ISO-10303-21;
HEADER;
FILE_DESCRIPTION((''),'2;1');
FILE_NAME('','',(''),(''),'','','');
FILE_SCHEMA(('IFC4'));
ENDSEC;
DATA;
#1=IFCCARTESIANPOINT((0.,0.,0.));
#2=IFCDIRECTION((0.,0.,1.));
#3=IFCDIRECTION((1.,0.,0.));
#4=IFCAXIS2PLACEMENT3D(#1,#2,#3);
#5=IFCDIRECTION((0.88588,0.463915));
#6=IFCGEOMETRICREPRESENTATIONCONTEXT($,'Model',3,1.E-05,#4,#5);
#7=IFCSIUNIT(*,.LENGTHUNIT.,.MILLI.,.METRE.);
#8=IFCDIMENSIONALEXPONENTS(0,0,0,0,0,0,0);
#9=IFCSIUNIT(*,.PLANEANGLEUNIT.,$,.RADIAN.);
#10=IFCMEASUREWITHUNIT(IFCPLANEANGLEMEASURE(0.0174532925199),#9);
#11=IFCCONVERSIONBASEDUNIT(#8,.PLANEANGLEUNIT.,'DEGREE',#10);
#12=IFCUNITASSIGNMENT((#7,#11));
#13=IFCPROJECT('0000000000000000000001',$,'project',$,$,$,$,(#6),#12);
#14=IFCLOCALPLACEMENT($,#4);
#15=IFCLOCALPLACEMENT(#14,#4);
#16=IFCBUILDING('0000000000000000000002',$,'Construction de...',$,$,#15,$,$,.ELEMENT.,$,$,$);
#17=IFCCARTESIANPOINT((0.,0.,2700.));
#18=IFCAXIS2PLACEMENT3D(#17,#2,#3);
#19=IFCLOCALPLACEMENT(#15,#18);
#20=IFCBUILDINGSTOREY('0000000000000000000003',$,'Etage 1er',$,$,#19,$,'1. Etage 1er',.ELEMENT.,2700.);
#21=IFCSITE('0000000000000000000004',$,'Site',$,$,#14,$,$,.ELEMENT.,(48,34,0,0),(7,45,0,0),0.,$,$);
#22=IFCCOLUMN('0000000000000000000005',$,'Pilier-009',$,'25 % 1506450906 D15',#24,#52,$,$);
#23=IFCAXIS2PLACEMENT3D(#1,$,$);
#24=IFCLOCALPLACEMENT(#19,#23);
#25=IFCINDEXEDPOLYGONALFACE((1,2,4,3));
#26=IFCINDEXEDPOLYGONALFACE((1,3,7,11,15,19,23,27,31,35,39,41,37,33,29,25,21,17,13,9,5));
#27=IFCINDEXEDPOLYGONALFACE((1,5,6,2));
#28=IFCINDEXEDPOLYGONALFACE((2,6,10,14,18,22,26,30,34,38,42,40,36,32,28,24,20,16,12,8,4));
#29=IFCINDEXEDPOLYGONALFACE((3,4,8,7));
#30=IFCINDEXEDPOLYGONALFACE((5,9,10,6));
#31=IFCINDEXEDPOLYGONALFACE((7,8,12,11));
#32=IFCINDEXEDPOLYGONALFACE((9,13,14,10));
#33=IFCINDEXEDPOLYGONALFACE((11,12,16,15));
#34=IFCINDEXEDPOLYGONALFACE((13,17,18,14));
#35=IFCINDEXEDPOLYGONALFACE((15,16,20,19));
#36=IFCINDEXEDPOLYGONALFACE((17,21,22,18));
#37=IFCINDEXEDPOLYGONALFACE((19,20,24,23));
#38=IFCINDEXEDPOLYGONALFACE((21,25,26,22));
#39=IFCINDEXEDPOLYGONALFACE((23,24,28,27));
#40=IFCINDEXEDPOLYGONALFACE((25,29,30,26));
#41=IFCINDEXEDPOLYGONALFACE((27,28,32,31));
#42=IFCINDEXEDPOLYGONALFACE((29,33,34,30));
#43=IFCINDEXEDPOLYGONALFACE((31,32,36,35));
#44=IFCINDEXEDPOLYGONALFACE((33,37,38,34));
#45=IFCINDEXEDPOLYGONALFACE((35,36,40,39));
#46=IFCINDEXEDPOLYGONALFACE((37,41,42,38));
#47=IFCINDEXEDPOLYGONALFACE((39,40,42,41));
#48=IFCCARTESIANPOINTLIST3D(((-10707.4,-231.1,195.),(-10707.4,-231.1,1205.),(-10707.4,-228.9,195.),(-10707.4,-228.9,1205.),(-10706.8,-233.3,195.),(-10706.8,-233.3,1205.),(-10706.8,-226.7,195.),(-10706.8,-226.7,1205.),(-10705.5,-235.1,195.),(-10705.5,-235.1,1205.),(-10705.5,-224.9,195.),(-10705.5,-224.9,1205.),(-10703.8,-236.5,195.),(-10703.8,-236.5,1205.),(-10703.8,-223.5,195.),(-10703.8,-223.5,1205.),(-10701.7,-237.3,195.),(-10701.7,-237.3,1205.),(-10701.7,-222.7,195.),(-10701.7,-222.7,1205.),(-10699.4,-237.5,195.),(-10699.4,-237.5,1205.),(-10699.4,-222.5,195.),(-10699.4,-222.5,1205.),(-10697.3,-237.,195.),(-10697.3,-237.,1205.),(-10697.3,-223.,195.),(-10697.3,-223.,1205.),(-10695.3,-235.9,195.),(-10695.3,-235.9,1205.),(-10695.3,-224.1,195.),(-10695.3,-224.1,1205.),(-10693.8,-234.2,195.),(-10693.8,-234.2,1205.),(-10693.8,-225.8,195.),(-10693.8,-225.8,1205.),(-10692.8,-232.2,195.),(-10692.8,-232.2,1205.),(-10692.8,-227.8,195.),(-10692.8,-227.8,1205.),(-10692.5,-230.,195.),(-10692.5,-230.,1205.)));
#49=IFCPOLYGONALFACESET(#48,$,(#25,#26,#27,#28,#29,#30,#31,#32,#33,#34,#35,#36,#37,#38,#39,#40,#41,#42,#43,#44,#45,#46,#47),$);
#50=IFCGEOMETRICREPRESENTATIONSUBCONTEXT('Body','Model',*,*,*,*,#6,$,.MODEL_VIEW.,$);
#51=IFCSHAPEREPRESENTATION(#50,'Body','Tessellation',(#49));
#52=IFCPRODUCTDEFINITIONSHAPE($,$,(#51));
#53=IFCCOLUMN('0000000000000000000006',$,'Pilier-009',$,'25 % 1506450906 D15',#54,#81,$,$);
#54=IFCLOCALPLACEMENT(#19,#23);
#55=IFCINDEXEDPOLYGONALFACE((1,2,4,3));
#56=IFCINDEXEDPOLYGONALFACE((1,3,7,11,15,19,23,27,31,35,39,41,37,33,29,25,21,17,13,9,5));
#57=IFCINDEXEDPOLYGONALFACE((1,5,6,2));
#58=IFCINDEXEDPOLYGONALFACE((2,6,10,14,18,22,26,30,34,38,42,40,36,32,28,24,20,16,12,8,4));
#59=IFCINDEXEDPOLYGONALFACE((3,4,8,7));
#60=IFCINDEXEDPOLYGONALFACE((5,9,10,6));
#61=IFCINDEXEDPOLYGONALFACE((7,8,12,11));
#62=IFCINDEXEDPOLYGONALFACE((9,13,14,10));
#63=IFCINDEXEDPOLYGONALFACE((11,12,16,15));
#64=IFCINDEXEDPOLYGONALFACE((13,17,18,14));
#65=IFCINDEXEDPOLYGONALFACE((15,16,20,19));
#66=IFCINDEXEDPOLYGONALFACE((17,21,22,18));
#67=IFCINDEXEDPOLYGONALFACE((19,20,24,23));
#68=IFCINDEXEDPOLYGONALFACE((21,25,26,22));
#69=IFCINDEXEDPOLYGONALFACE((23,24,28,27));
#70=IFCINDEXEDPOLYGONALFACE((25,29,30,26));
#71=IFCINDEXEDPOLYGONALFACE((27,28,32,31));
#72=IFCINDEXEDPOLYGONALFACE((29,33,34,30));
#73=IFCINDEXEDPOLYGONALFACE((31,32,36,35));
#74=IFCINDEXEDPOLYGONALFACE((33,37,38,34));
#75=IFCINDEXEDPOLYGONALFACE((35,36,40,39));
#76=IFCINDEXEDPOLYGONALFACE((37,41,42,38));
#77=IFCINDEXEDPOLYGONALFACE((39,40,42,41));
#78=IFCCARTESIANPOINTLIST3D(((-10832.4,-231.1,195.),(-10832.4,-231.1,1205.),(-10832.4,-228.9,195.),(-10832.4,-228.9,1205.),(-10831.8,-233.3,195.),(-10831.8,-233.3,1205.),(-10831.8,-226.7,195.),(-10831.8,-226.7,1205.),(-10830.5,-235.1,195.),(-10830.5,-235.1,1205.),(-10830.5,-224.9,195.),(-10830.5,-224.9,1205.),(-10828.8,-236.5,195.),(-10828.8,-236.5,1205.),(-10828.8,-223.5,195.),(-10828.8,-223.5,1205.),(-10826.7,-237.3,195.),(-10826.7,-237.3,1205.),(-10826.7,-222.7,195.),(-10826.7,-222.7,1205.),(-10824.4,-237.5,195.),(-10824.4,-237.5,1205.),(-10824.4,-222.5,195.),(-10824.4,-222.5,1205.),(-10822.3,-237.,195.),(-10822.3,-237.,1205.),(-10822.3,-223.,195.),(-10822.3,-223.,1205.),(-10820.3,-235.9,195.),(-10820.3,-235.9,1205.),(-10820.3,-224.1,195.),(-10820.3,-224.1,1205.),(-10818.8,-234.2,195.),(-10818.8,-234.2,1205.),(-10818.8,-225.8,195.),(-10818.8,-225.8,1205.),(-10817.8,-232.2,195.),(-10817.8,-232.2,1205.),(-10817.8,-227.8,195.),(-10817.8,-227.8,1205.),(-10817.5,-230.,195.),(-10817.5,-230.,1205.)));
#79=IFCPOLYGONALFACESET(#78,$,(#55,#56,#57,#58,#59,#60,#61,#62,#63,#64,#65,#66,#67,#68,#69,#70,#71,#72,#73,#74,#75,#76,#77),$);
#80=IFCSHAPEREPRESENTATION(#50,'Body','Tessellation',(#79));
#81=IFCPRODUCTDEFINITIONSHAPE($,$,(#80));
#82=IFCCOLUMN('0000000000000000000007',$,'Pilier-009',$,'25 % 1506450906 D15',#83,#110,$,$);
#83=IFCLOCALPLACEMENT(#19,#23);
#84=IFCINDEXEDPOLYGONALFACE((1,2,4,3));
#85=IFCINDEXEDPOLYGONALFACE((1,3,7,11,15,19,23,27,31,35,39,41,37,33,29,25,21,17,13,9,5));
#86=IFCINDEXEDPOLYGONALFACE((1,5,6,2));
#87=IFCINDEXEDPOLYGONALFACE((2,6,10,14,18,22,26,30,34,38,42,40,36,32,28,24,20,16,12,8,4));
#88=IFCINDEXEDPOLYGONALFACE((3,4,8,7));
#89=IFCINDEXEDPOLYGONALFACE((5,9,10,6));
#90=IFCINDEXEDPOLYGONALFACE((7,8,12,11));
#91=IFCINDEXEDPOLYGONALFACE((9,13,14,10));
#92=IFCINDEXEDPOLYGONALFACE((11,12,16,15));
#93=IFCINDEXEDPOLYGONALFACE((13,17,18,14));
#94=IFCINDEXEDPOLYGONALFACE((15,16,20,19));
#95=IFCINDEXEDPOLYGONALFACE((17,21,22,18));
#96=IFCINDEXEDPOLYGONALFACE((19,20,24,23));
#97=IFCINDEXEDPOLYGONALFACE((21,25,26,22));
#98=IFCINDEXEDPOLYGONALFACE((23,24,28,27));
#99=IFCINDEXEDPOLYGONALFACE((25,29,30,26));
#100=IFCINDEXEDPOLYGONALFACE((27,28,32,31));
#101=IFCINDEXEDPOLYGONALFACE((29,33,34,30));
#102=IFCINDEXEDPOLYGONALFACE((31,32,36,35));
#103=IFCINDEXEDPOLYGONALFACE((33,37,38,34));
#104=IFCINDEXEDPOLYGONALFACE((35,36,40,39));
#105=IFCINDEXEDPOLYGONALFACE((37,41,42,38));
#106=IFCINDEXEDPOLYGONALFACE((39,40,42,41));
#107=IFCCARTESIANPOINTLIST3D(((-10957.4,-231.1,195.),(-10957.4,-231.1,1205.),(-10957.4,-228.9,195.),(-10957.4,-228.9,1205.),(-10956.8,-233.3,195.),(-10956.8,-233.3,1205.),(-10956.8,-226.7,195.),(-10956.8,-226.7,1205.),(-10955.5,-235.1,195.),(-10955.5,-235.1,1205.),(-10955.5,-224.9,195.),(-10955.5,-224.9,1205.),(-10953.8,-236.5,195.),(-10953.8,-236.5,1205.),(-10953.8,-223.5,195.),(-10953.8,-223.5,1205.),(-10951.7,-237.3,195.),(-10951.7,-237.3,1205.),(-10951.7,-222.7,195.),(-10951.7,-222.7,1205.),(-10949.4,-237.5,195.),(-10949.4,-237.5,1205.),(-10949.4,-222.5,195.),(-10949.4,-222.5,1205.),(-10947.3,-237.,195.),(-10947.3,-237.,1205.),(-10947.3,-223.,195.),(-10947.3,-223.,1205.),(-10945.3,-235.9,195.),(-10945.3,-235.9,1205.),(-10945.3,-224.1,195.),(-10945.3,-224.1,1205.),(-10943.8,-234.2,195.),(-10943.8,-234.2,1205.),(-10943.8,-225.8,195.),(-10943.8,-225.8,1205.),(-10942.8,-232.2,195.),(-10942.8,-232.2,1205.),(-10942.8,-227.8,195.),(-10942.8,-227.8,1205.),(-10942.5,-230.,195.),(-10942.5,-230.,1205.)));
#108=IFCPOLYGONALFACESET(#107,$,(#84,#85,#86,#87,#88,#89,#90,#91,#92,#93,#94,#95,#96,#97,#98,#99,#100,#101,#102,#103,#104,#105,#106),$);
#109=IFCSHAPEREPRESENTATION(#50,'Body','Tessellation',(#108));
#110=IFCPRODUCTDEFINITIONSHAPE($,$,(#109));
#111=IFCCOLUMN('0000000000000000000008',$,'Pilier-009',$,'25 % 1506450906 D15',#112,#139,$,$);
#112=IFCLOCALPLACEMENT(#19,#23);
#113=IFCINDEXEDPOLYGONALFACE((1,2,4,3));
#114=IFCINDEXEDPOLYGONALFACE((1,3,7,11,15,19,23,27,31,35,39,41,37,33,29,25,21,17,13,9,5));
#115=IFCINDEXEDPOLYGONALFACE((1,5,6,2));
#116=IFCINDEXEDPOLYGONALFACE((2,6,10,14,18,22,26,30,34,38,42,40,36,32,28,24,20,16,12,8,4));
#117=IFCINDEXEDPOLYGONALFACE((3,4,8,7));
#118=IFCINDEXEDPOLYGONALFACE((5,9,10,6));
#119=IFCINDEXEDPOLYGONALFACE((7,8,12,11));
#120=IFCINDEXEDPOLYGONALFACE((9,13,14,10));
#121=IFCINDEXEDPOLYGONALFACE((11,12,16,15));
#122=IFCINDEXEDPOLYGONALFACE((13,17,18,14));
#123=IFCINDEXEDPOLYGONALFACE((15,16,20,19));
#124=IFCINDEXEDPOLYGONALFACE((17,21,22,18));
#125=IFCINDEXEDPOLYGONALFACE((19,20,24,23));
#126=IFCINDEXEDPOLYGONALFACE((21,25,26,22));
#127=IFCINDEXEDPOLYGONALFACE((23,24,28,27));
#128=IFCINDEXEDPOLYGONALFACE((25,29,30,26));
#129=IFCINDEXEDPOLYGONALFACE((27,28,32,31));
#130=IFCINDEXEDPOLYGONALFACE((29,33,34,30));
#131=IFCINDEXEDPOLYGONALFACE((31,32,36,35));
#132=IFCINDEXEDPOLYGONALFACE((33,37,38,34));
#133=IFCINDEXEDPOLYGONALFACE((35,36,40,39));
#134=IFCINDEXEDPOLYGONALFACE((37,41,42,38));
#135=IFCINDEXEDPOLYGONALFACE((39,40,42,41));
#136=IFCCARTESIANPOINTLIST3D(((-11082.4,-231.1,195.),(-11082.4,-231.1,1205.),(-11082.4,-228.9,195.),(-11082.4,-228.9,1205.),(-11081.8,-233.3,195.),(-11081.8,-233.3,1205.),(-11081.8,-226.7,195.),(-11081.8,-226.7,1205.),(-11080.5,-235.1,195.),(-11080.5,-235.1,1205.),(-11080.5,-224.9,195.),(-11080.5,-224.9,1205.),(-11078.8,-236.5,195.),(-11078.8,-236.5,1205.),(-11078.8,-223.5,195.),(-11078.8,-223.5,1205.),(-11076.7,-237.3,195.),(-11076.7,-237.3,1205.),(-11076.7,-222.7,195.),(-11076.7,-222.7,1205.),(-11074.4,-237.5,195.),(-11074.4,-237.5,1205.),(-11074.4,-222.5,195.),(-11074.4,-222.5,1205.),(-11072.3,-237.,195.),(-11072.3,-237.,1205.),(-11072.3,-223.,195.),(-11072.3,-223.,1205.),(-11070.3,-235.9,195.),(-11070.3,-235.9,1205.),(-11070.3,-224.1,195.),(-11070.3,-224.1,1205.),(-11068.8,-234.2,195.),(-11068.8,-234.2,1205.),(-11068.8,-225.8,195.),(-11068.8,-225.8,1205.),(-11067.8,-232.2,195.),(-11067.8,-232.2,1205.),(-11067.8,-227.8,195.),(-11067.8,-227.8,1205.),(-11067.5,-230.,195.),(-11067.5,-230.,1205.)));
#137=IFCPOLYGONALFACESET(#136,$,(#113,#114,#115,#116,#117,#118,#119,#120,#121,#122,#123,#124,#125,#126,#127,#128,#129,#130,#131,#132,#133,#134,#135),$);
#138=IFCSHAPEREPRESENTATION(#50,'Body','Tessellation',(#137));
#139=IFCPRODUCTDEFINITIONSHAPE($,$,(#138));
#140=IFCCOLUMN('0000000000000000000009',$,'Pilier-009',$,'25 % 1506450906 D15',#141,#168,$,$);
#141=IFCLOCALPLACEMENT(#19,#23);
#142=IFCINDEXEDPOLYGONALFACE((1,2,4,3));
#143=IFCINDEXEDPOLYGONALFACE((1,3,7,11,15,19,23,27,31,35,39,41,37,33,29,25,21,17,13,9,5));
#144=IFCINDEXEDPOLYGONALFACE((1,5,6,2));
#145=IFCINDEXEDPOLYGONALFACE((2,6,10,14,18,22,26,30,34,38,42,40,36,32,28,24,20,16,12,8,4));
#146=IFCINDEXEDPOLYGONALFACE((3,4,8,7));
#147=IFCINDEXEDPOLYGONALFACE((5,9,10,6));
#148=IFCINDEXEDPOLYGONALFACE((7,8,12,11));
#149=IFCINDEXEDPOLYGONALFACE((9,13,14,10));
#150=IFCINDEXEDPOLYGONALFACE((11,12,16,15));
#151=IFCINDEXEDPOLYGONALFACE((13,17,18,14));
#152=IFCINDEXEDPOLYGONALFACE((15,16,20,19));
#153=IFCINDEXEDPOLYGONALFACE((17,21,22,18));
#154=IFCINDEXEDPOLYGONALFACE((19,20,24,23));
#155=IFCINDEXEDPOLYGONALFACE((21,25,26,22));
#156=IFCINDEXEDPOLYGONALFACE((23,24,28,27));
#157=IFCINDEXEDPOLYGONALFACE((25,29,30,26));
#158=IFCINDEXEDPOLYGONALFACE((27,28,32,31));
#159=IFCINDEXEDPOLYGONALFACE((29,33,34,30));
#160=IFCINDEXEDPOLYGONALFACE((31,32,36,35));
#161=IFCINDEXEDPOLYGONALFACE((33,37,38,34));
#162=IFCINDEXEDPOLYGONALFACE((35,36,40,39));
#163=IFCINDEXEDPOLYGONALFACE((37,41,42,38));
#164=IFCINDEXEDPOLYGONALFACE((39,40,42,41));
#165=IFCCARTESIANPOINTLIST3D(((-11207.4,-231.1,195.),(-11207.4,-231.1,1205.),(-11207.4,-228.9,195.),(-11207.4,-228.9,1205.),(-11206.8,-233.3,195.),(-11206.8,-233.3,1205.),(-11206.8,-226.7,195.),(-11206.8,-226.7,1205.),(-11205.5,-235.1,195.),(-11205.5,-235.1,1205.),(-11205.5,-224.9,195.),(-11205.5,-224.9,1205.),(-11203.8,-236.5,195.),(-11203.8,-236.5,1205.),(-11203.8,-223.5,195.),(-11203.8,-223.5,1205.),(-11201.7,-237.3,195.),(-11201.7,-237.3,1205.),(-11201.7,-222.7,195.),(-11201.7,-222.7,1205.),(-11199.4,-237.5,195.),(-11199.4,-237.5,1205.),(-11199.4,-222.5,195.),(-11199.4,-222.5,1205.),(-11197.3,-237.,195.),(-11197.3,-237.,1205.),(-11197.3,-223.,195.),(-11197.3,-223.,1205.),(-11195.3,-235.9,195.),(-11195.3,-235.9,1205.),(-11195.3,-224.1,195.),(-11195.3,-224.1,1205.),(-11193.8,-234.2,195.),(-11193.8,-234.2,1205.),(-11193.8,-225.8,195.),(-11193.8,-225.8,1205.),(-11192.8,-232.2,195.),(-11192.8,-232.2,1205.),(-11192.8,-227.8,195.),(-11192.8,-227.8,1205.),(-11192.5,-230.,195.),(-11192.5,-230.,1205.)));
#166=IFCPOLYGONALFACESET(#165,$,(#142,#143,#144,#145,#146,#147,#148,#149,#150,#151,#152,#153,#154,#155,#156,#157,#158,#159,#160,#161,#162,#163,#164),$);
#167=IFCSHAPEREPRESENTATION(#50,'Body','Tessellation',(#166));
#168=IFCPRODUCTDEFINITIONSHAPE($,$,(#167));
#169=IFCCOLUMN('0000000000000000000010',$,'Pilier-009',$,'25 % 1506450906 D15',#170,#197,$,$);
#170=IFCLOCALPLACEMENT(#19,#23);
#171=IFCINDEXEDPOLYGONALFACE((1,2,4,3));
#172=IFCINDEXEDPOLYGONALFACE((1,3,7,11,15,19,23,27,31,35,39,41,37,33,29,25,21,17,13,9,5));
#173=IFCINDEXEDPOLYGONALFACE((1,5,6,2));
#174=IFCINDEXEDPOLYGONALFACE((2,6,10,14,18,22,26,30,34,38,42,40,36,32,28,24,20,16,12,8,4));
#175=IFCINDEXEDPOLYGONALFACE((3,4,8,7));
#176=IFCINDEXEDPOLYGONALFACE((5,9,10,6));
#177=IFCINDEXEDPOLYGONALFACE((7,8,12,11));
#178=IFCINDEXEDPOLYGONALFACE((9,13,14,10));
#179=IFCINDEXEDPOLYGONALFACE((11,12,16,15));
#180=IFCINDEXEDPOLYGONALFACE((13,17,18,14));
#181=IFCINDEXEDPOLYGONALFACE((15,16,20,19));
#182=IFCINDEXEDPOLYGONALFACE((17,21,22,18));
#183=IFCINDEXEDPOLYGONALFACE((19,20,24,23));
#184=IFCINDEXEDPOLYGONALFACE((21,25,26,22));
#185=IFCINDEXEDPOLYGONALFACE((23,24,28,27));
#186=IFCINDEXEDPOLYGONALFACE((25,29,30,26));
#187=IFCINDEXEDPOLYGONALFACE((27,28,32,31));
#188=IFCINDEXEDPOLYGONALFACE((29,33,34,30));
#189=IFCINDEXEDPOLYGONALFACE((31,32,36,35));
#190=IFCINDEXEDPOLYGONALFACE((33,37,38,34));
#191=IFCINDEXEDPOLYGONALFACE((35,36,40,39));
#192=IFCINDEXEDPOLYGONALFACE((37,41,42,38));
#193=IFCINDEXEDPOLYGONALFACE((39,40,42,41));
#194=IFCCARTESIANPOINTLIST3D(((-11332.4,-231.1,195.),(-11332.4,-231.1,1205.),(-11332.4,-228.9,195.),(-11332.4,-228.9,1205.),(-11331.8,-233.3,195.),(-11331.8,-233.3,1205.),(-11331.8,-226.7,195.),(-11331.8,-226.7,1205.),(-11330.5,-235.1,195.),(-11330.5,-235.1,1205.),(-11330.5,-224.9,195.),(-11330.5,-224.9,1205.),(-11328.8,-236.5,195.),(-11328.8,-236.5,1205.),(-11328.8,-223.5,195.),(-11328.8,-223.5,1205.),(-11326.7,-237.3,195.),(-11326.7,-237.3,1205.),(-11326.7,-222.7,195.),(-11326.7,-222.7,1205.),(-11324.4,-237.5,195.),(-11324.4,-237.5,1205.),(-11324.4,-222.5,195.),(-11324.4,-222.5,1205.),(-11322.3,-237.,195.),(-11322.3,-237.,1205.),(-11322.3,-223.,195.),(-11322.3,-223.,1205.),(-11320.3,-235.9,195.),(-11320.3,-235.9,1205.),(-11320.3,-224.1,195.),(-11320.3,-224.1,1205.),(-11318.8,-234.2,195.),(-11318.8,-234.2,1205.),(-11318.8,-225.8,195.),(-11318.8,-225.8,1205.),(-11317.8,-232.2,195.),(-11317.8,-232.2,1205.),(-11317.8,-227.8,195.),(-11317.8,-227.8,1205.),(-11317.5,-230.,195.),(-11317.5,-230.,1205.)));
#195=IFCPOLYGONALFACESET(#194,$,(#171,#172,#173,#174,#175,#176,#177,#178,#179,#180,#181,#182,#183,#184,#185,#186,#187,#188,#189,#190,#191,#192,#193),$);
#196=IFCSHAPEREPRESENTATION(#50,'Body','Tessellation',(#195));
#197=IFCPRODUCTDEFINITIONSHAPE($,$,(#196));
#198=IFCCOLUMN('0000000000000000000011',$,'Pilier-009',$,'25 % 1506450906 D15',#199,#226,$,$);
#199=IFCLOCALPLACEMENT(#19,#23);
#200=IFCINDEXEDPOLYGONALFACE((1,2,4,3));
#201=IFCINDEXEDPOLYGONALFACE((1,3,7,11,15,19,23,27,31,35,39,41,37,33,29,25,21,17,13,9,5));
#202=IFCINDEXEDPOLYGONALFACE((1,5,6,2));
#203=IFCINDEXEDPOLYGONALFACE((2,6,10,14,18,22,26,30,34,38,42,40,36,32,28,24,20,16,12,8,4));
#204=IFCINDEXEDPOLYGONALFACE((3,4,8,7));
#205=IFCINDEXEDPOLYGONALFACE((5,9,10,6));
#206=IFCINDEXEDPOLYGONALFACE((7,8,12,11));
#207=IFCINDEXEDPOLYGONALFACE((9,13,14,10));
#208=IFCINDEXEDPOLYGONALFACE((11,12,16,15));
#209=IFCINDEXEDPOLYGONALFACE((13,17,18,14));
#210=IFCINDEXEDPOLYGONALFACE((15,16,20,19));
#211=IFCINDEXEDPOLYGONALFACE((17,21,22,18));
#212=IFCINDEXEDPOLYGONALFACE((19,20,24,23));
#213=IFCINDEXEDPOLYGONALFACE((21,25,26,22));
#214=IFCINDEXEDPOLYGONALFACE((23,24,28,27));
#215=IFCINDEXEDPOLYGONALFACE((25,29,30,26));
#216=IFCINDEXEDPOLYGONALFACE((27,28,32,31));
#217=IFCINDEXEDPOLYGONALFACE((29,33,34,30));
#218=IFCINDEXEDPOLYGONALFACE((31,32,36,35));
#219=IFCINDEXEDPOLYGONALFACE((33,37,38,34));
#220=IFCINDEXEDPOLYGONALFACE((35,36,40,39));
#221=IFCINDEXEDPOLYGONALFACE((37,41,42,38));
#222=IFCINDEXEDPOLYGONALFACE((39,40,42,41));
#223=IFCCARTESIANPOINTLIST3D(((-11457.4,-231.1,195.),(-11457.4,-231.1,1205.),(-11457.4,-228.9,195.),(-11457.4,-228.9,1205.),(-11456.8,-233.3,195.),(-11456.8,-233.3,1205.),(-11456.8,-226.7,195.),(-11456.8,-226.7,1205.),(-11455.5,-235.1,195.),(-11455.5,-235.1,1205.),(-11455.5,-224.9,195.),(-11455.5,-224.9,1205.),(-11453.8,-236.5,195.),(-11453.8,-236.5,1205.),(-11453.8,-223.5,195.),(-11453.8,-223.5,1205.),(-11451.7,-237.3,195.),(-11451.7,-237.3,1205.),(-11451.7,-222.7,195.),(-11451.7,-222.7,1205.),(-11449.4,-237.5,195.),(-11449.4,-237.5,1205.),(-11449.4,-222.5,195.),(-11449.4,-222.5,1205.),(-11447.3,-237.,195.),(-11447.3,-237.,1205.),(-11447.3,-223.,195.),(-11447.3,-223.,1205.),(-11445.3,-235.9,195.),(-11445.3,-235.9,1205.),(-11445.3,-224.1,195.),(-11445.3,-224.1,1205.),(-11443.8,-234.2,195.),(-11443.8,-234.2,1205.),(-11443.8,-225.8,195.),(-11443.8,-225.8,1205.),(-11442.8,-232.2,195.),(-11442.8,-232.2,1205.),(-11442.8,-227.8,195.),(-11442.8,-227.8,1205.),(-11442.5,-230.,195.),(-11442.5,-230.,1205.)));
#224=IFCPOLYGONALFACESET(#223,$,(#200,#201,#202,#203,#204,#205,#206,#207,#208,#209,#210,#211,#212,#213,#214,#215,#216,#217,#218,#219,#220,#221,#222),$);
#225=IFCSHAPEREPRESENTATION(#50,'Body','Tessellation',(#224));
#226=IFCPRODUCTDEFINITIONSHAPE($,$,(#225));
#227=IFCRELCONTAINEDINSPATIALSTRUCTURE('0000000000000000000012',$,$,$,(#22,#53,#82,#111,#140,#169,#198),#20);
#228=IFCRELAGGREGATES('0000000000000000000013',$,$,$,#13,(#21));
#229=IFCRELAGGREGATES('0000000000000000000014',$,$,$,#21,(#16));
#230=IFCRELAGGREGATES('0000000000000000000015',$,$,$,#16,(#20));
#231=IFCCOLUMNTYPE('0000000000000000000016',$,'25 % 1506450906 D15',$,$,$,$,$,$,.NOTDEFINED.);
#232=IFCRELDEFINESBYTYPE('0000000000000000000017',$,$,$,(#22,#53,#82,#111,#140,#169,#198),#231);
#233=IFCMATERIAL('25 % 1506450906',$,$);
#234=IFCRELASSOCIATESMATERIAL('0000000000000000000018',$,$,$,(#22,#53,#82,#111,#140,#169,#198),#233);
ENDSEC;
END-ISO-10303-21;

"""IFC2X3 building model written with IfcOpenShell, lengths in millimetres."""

from ifc_helpers import new_model, entity, si_unit, converted_unit, direction, frame, origin_with_axes, origin_2d_with_axis, place, context, subcontext, project, spatial, circle, extrude, material, type_object, element, save


model = new_model("IFC2X3")

# Units and contexts
model_context = context("Model", 3, precision=1e-05, world=origin_with_axes(), true_north=direction((0.88588, 0.463915)))
body_context = subcontext(model_context, "Body", "Model", "MODEL_VIEW")
ifc_project = project(units=[si_unit("LENGTHUNIT", "METRE", prefix="MILLI"), converted_unit("PLANEANGLEUNIT", "DEGREE", entity("IfcPlaneAngleMeasure", 0.0174532925199), si_unit("PLANEANGLEUNIT", "RADIAN"), dimensions=[0, 0, 0, 0, 0, 0, 0])], contexts=[model_context])

# Site, building, storey
site_placement = place(None, origin_with_axes())
site = spatial("IfcSite", under=ifc_project, at=site_placement, Name="Site", CompositionType="ELEMENT", RefLatitude=(48, 34, 0, 0), RefLongitude=(7, 45, 0, 0), RefElevation=0.0)
building_placement = place(site_placement, origin_with_axes())
building = spatial("IfcBuilding", under=site, at=building_placement, Name="Construction de...", CompositionType="ELEMENT")
storey_placement = place(building_placement, frame((0.0, 0.0, 2700.0), z_axis=(0.0, 0.0, 1.0), x_axis=(1.0, 0.0, 0.0)))
storey = spatial("IfcBuildingStorey", under=building, at=storey_placement, Name="Etage 1er", LongName="1. Etage 1er", CompositionType="ELEMENT", Elevation=2700.0)

# Columns
ifc_material = material(Name="25 % 1506450906")
column_type = type_object("IfcColumnType", Name="25 % 1506450906 D15", PredefinedType="NOTDEFINED")
for number, where, z_axis, x_axis, name in (
    (1, (-10700.0, -230.0, 195.0), (0.0, 0.0, 1.0), (1.0, 0.0, 0.0), "Pilier-009"),
    (2, (-10825.0, -230.0, 195.0), (0.0, 0.0, 1.0), (1.0, 0.0, 0.0), "Pilier-009"),
    (3, (-10950.0, -230.0, 195.0), (0.0, 0.0, 1.0), (1.0, 0.0, 0.0), "Pilier-009"),
    (4, (-11075.0, -230.0, 195.0), (0.0, 0.0, 1.0), (1.0, 0.0, 0.0), "Pilier-009"),
    (5, (-11200.0, -230.0, 195.0), (0.0, 0.0, 1.0), (1.0, 0.0, 0.0), "Pilier-009"),
    (6, (-11325.0, -230.0, 195.0), (0.0, 0.0, 1.0), (1.0, 0.0, 0.0), "Pilier-009"),
    (7, (-11450.0, -230.0, 195.0), (0.0, 0.0, 1.0), (1.0, 0.0, 0.0), "Pilier-009"),
):
    element("IfcColumn", number, at=place(storey_placement, frame(where, z_axis=z_axis, x_axis=x_axis)), inside=storey, type_object=column_type, material=ifc_material, Name=name, ObjectType="25 % 1506450906 D15", context=body_context, shape_type="SweptSolid", body=[
        extrude(circle(Radius=7.5, at=origin_2d_with_axis()), origin_with_axes(), (0.0, 0.0, 1.0), 1010.0),
    ])

save(model, "model.ifc")
